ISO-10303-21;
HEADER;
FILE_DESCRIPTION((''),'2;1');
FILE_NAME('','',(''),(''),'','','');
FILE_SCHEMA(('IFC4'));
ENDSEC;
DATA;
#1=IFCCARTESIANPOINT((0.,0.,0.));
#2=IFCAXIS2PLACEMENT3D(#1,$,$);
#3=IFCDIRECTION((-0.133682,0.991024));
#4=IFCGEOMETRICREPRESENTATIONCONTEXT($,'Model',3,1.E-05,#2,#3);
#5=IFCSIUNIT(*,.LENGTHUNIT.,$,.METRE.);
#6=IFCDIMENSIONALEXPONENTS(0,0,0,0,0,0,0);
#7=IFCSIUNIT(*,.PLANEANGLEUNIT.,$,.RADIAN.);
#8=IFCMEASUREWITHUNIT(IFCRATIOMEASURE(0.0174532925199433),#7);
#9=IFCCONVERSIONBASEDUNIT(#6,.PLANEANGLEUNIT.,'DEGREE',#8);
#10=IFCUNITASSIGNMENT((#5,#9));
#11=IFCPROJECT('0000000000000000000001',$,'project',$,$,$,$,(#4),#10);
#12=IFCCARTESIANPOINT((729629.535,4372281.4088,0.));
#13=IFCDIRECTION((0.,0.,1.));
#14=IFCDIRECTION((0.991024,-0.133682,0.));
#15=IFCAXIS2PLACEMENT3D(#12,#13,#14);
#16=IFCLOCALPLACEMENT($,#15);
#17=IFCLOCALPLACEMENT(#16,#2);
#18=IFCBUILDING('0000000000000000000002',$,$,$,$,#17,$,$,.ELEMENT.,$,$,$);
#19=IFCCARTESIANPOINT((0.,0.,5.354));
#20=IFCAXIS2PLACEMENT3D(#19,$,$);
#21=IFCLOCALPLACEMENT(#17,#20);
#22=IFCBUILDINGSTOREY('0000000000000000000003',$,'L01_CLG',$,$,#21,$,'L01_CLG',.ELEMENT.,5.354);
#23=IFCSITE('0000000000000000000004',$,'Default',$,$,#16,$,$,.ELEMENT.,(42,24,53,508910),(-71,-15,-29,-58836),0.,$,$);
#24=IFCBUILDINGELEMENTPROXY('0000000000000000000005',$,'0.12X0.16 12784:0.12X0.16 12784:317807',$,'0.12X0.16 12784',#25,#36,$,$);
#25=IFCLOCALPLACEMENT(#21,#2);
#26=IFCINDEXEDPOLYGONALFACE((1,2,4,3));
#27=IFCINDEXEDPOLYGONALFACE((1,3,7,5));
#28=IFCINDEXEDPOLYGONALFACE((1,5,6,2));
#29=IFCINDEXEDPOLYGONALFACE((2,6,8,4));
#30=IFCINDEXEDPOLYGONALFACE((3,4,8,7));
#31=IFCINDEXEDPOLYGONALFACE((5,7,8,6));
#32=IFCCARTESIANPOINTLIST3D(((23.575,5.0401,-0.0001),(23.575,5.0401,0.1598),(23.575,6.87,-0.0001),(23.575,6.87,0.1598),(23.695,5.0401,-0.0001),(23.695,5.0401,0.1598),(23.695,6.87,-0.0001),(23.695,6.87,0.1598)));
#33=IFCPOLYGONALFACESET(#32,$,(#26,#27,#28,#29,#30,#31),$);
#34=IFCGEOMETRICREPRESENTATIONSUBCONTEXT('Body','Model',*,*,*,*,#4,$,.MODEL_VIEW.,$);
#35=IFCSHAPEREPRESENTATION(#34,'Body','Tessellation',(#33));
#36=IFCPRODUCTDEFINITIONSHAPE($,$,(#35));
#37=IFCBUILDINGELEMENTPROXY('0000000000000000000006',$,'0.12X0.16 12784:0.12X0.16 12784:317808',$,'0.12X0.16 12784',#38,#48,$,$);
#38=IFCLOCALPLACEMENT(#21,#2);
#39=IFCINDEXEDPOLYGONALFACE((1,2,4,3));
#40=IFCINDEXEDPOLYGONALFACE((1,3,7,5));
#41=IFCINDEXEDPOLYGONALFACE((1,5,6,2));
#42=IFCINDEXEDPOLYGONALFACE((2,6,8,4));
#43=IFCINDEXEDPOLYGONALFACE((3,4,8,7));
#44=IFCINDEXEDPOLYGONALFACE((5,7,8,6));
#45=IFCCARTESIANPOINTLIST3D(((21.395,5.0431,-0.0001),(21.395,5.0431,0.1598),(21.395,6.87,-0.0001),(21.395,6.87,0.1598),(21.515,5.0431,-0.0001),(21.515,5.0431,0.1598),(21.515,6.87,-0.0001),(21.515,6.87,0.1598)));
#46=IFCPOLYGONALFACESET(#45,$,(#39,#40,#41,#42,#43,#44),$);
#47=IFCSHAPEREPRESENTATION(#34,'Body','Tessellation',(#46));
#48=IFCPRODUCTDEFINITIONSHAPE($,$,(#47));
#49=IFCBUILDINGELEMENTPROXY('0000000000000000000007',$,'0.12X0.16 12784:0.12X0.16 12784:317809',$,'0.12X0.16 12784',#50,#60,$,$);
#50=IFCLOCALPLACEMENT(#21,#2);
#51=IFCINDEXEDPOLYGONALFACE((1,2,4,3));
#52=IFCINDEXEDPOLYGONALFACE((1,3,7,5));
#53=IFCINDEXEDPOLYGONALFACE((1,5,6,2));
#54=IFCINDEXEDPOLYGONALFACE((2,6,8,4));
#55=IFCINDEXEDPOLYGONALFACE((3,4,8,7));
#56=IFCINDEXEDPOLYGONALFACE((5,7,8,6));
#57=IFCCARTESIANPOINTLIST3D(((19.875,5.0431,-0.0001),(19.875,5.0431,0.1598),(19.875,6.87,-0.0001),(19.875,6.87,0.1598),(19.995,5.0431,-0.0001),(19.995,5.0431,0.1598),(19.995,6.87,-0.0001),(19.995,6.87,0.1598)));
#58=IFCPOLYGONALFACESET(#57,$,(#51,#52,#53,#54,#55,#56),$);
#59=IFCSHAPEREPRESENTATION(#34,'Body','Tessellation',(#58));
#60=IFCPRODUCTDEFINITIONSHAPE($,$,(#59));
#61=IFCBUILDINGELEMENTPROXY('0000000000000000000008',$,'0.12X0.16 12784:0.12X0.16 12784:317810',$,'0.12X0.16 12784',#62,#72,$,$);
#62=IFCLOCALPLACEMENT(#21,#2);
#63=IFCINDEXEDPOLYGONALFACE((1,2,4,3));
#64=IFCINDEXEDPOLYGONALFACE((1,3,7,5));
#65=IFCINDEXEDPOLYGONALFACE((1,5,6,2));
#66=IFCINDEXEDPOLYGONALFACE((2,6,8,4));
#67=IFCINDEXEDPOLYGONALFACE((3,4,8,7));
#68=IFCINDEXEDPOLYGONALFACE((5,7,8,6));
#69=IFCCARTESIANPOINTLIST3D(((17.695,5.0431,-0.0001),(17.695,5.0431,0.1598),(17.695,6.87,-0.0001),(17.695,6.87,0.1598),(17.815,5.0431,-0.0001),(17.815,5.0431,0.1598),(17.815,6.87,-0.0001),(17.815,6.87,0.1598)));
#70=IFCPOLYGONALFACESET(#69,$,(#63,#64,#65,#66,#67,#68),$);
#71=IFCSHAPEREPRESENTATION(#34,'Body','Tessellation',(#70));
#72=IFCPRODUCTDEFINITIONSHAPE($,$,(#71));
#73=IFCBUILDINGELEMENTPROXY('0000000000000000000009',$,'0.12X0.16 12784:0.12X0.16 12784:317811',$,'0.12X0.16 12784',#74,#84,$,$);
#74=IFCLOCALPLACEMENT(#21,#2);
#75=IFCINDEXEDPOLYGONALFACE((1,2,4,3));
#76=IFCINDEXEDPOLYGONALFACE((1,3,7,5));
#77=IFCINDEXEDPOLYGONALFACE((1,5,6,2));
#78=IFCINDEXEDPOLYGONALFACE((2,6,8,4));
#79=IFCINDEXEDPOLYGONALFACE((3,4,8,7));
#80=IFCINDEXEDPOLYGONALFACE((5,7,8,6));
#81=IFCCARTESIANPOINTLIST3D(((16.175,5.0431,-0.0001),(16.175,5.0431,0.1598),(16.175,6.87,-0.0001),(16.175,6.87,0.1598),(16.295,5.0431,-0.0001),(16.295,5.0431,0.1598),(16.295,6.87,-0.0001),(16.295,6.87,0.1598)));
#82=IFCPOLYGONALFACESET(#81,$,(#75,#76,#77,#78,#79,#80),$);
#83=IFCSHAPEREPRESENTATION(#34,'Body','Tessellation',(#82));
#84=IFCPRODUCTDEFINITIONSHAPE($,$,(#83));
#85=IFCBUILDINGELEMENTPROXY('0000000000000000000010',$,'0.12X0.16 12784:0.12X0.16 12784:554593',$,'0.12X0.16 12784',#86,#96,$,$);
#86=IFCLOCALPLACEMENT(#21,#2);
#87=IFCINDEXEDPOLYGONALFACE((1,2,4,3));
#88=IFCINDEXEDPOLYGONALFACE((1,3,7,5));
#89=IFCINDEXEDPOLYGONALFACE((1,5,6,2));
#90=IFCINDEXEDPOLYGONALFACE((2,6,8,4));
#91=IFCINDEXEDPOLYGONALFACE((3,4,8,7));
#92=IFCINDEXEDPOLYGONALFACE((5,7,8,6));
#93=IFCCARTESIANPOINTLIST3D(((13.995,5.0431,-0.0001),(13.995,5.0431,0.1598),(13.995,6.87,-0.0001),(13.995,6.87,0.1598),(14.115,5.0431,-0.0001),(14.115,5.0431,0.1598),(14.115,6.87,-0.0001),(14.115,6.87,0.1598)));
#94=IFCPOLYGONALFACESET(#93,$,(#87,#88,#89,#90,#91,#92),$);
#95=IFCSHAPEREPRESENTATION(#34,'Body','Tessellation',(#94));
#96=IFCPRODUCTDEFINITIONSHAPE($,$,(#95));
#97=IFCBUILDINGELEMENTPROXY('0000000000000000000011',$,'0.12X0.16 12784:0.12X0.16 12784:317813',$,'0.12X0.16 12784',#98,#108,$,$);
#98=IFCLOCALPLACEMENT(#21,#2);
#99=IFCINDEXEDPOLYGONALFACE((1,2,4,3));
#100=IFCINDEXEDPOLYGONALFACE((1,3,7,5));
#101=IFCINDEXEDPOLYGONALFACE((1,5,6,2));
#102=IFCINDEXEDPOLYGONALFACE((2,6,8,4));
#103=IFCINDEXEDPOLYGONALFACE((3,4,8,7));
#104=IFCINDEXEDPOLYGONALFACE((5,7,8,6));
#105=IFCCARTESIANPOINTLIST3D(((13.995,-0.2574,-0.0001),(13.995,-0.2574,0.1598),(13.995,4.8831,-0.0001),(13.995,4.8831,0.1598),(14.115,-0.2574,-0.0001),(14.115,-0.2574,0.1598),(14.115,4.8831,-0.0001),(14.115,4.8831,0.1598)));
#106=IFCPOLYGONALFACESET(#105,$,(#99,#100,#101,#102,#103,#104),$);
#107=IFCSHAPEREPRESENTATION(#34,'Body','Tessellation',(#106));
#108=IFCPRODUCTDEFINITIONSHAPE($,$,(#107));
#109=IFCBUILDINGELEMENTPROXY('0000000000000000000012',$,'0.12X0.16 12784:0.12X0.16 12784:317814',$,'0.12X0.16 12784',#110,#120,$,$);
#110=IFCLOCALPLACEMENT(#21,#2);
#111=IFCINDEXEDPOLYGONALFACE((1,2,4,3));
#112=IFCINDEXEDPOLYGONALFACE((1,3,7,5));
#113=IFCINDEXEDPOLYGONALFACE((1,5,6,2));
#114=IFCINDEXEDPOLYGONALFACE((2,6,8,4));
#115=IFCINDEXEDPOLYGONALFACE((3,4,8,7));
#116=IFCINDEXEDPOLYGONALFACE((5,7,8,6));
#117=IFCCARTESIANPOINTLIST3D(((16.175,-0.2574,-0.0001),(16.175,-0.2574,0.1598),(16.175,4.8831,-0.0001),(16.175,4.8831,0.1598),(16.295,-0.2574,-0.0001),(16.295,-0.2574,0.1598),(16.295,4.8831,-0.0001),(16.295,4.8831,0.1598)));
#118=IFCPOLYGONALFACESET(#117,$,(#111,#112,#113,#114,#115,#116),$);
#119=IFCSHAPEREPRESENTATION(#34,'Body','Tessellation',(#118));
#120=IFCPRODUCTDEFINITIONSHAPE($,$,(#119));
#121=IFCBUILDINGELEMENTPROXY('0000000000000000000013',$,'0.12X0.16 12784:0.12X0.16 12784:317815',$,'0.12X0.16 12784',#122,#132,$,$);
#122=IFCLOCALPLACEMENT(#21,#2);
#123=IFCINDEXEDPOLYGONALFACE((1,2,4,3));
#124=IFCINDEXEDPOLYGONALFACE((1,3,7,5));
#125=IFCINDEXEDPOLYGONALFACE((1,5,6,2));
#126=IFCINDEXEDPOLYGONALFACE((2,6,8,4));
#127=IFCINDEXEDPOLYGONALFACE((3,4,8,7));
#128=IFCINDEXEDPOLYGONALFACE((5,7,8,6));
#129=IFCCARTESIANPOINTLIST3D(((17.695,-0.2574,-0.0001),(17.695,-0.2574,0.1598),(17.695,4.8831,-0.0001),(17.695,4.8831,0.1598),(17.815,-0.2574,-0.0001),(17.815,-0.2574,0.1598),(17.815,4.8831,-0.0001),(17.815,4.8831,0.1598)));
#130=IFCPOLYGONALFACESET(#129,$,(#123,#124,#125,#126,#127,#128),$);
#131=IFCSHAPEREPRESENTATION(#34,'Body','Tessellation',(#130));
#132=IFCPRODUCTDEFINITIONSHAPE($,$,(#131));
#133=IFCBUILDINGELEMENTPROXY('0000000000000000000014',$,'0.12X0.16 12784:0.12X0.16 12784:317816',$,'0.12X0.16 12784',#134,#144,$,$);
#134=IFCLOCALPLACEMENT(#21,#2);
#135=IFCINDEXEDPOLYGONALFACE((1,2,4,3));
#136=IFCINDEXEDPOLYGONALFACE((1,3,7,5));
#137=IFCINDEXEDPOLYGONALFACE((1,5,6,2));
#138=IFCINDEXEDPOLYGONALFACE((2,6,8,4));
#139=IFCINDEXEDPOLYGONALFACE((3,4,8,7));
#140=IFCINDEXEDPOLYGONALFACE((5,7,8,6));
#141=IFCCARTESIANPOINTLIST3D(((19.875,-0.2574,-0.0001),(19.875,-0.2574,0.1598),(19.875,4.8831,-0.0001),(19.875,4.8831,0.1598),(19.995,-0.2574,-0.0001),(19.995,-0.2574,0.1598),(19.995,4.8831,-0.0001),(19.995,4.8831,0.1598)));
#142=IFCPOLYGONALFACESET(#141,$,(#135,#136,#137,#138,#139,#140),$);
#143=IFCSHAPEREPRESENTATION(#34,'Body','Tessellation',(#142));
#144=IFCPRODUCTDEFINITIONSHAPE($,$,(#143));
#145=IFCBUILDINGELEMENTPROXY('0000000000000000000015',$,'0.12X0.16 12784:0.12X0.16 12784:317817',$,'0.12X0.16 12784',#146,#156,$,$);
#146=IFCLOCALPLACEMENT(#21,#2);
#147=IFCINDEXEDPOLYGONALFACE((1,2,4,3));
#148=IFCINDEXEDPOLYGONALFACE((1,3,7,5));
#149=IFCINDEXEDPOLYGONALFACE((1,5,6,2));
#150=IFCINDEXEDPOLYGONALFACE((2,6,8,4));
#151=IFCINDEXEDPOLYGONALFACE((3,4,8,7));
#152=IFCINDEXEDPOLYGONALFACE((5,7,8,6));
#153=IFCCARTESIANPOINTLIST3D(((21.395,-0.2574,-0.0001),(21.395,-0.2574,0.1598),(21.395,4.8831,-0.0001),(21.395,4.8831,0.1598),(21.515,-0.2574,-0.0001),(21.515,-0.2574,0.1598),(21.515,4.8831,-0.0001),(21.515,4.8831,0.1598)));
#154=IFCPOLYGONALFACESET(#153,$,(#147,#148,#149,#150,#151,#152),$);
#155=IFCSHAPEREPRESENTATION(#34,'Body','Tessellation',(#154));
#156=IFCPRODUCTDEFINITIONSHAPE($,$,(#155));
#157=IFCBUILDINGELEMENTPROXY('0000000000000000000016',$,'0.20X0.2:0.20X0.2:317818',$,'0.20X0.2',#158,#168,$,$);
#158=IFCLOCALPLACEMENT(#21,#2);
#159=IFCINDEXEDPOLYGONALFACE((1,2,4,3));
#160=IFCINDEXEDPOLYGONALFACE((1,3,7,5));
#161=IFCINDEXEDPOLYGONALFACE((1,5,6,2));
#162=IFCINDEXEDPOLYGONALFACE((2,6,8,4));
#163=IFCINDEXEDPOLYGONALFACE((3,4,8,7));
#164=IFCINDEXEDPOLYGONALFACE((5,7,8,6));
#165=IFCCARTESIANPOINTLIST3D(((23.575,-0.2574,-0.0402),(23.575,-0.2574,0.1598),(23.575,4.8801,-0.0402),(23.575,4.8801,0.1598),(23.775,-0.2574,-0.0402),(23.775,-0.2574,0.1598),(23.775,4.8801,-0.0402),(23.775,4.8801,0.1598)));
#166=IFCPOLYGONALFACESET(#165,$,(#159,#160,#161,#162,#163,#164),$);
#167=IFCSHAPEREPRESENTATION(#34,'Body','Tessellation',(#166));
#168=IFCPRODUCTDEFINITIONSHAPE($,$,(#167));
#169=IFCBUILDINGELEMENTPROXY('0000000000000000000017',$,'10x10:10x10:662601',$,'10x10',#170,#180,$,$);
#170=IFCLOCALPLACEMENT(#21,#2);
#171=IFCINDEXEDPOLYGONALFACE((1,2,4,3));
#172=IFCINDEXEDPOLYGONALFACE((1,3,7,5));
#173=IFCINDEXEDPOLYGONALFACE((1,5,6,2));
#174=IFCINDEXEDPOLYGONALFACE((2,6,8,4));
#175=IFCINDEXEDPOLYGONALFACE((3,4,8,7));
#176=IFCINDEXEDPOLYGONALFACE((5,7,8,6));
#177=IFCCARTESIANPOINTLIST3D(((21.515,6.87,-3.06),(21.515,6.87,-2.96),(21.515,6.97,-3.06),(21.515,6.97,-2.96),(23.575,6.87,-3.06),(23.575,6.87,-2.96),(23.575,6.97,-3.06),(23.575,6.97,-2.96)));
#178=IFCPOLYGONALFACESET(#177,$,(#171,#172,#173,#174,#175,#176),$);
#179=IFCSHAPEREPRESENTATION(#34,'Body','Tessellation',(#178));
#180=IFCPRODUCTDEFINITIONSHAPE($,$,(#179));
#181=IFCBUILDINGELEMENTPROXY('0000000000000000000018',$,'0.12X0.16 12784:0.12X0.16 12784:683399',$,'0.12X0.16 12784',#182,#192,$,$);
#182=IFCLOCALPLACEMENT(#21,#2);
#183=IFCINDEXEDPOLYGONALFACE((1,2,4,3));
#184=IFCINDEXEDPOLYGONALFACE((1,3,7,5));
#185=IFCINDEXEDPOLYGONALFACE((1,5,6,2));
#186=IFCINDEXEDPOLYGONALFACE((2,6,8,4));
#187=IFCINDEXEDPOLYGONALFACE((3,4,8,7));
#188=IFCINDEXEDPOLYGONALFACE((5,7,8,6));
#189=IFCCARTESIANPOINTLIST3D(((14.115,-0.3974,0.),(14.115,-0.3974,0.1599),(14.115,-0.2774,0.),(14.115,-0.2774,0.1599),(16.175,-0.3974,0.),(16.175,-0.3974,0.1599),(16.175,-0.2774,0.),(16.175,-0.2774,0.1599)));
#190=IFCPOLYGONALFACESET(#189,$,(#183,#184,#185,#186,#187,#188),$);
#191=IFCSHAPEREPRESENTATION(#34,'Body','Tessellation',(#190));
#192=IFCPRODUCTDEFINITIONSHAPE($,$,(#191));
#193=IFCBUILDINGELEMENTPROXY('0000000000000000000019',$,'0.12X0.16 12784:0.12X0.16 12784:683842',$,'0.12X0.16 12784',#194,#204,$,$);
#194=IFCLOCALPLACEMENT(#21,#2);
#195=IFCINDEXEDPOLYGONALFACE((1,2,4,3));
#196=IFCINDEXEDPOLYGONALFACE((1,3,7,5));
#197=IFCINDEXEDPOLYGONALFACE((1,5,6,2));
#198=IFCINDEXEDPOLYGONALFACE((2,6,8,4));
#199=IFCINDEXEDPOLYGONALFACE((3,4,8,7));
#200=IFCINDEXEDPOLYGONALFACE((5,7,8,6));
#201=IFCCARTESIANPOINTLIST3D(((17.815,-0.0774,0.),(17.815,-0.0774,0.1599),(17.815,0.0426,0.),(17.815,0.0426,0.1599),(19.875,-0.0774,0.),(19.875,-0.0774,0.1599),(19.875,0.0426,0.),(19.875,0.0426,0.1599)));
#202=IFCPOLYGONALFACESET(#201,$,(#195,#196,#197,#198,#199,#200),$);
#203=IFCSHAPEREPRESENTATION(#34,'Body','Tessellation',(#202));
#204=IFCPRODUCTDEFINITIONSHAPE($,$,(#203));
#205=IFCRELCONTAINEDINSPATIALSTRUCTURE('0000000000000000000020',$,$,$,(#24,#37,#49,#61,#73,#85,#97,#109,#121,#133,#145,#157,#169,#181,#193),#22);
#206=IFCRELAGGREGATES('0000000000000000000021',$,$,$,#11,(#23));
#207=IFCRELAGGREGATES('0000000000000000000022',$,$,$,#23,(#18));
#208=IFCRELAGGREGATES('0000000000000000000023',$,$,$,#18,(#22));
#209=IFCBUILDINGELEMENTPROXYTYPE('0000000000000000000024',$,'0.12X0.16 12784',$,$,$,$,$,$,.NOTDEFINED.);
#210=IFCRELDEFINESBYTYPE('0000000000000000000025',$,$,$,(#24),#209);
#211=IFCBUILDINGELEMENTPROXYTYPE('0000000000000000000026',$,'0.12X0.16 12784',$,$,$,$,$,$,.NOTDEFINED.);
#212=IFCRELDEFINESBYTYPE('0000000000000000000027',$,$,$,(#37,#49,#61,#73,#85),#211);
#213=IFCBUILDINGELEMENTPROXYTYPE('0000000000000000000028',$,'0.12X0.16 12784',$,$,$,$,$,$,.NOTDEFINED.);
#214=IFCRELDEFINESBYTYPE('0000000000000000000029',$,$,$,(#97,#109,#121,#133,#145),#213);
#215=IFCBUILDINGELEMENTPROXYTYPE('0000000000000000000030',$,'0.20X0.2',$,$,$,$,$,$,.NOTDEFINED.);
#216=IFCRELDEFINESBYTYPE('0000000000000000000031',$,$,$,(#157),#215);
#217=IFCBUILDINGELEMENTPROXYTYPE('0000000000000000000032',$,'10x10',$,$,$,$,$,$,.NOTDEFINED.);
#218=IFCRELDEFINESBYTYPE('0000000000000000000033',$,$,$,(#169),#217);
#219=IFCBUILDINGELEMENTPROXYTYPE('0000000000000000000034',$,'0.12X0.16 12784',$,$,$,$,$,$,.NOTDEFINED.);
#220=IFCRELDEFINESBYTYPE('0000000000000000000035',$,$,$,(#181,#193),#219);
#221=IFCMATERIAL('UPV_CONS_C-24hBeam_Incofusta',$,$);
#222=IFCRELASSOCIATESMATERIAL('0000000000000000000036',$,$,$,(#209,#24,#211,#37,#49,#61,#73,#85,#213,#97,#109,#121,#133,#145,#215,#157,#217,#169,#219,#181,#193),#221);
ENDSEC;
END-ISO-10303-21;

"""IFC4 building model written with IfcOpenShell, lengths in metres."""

from ifc_helpers import new_model, entity, si_unit, converted_unit, direction, frame, frame_2d, origin, origin_2d_with_axis, place, context, subcontext, project, spatial, rectangle, extrude, source, transform, mapped, material, type_object, type_shapes, element, save


model = new_model("IFC4")

# Units and contexts
model_context = context("Model", 3, precision=1e-05, world=origin(), true_north=direction((-0.133682, 0.991024)))
body_context = subcontext(model_context, "Body", "Model", "MODEL_VIEW")
ifc_project = project(units=[si_unit("LENGTHUNIT", "METRE"), converted_unit("PLANEANGLEUNIT", "DEGREE", entity("IfcRatioMeasure", 0.0174532925199433), si_unit("PLANEANGLEUNIT", "RADIAN"), dimensions=[0, 0, 0, 0, 0, 0, 0])], contexts=[model_context])

# Site, building, storey
site_placement = place(None, frame((729629.535, 4372281.4088, 0.0), z_axis=(0.0, 0.0, 1.0), x_axis=(0.991024, -0.133682, 0.0)))
site = spatial("IfcSite", under=ifc_project, at=site_placement, Name="Default", CompositionType="ELEMENT", RefLatitude=(42, 24, 53, 508910), RefLongitude=(-71, -15, -29, -58836), RefElevation=0.0)
building_placement = place(site_placement, origin())
building = spatial("IfcBuilding", under=site, at=building_placement, CompositionType="ELEMENT")
storey_placement = place(building_placement, frame((0.0, 0.0, 5.354)))
storey = spatial("IfcBuildingStorey", under=building, at=storey_placement, Name="L01_CLG", LongName="L01_CLG", CompositionType="ELEMENT", Elevation=5.354)

# Building element proxies
ifc_material_1 = material(Name="UPV_CONS_C-24hBeam_Incofusta")
building_element_proxy_type_1 = type_object("IfcBuildingElementProxyType", Name="0.12X0.16 12784", material=ifc_material_1)
shared_shape_1 = source(origin(), body_context, "Body", "SweptSolid", [
    extrude(rectangle(XDim=0.12, YDim=1.8299, at=frame_2d((0.0, 0.0), x_axis=(1.0, 0.0))), frame((0.9149, 0.06, 0.0), z_axis=(0.0, 0.0, 1.0), x_axis=(0.0, -1.0, 0.0)), (0.0, 0.0, 1.0), 0.1599),
])
type_shapes(building_element_proxy_type_1, [shared_shape_1])
proxy_1_placement = place(storey_placement, frame((23.575, 6.87, -0.0001), z_axis=(0.0, 0.0, 1.0), x_axis=(0.0, -1.0, 0.0)))
element("IfcBuildingElementProxy", 1, at=proxy_1_placement, inside=storey, type_object=building_element_proxy_type_1, material=ifc_material_1, Name="0.12X0.16 12784:0.12X0.16 12784:317807", ObjectType="0.12X0.16 12784", context=body_context, shape_type="MappedRepresentation", body=[
    mapped(shared_shape_1, transform((0.0, 0.0, 0.0), scale=1.0)),
])
building_element_proxy_type_2 = type_object("IfcBuildingElementProxyType", Name="0.12X0.16 12784", material=ifc_material_1)
shared_shape_2 = source(origin(), body_context, "Body", "SweptSolid", [
    extrude(rectangle(XDim=0.12, YDim=1.8269, at=frame_2d((0.0, 0.0), x_axis=(1.0, 0.0))), frame((0.9135, 0.06, 0.0), z_axis=(0.0, 0.0, 1.0), x_axis=(0.0, -1.0, 0.0)), (0.0, 0.0, 1.0), 0.1599),
])
type_shapes(building_element_proxy_type_2, [shared_shape_2])
for number, where, z_axis, x_axis, name in (
    (2, (21.395, 6.87, -0.0001), (0.0, 0.0, 1.0), (0.0, -1.0, 0.0), "0.12X0.16 12784:0.12X0.16 12784:317808"),
    (3, (19.875, 6.87, -0.0001), (0.0, 0.0, 1.0), (0.0, -1.0, 0.0), "0.12X0.16 12784:0.12X0.16 12784:317809"),
    (4, (17.695, 6.87, -0.0001), (0.0, 0.0, 1.0), (0.0, -1.0, 0.0), "0.12X0.16 12784:0.12X0.16 12784:317810"),
    (5, (16.175, 6.87, -0.0001), (0.0, 0.0, 1.0), (0.0, -1.0, 0.0), "0.12X0.16 12784:0.12X0.16 12784:317811"),
    (6, (13.995, 6.87, -0.0001), (0.0, 0.0, 1.0), (0.0, -1.0, 0.0), "0.12X0.16 12784:0.12X0.16 12784:554593"),
):
    element("IfcBuildingElementProxy", number, at=place(storey_placement, frame(where, z_axis=z_axis, x_axis=x_axis)), inside=storey, type_object=building_element_proxy_type_2, material=ifc_material_1, Name=name, ObjectType="0.12X0.16 12784", context=body_context, shape_type="MappedRepresentation", body=[
        mapped(shared_shape_2, transform((0.0, 0.0, 0.0), scale=1.0)),
    ])
building_element_proxy_type_3 = type_object("IfcBuildingElementProxyType", Name="0.12X0.16 12784", material=ifc_material_1)
shared_shape_3 = source(origin(), body_context, "Body", "SweptSolid", [
    extrude(rectangle(XDim=0.12, YDim=5.1404, at=origin_2d_with_axis()), frame((-0.0488, 0.0, -0.0799), z_axis=(0.0, 0.0, 1.0), x_axis=(0.0, -1.0, 0.0)), (0.0, 0.0, 1.0), 0.1599),
])
type_shapes(building_element_proxy_type_3, [shared_shape_3])
for number, where, z_axis, x_axis, name in (
    (7, (14.055, 2.3616, 0.0798), (0.0, 0.0, 1.0), (0.0, 1.0, 0.0), "0.12X0.16 12784:0.12X0.16 12784:317813"),
    (8, (16.235, 2.3616, 0.0798), (0.0, 0.0, 1.0), (0.0, 1.0, 0.0), "0.12X0.16 12784:0.12X0.16 12784:317814"),
    (9, (17.755, 2.3616, 0.0798), (0.0, 0.0, 1.0), (0.0, 1.0, 0.0), "0.12X0.16 12784:0.12X0.16 12784:317815"),
    (10, (19.935, 2.3616, 0.0798), (0.0, 0.0, 1.0), (0.0, 1.0, 0.0), "0.12X0.16 12784:0.12X0.16 12784:317816"),
    (11, (21.455, 2.3616, 0.0798), (0.0, 0.0, 1.0), (0.0, 1.0, 0.0), "0.12X0.16 12784:0.12X0.16 12784:317817"),
):
    element("IfcBuildingElementProxy", number, at=place(storey_placement, frame(where, z_axis=z_axis, x_axis=x_axis)), inside=storey, type_object=building_element_proxy_type_3, material=ifc_material_1, Name=name, ObjectType="0.12X0.16 12784", context=body_context, shape_type="MappedRepresentation", body=[
        mapped(shared_shape_3, transform((0.0, 0.0, 0.0), scale=1.0)),
    ])
building_element_proxy_type_4 = type_object("IfcBuildingElementProxyType", Name="0.20X0.2", material=ifc_material_1)
shared_shape_4 = source(origin(), body_context, "Body", "SweptSolid", [
    extrude(rectangle(XDim=0.2, YDim=5.1375, at=origin_2d_with_axis()), frame((-0.0502, 0.0, -0.0999), z_axis=(0.0, 0.0, 1.0), x_axis=(0.0, -1.0, 0.0)), (0.0, 0.0, 1.0), 0.2),
])
type_shapes(building_element_proxy_type_4, [shared_shape_4])
proxy_2_placement = place(storey_placement, frame((23.675, 2.3616, 0.0597), z_axis=(0.0, 0.0, 1.0), x_axis=(0.0, 1.0, 0.0)))
element("IfcBuildingElementProxy", 12, at=proxy_2_placement, inside=storey, type_object=building_element_proxy_type_4, material=ifc_material_1, Name="0.20X0.2:0.20X0.2:317818", ObjectType="0.20X0.2", context=body_context, shape_type="MappedRepresentation", body=[
    mapped(shared_shape_4, transform((0.0, 0.0, 0.0), scale=1.0)),
])
building_element_proxy_type_5 = type_object("IfcBuildingElementProxyType", Name="10x10", material=ifc_material_1)
shared_shape_5 = source(origin(), body_context, "Body", "SweptSolid", [
    extrude(rectangle(XDim=0.1, YDim=2.06, at=frame_2d((0.0, 0.0), x_axis=(1.0, 0.0))), frame((1.03, 0.05, 0.0), z_axis=(0.0, 0.0, 1.0), x_axis=(0.0, -1.0, 0.0)), (0.0, 0.0, 1.0), 0.1),
])
type_shapes(building_element_proxy_type_5, [shared_shape_5])
proxy_3_placement = place(storey_placement, frame((21.515, 6.87, -3.06)))
element("IfcBuildingElementProxy", 13, at=proxy_3_placement, inside=storey, type_object=building_element_proxy_type_5, material=ifc_material_1, Name="10x10:10x10:662601", ObjectType="10x10", context=body_context, shape_type="MappedRepresentation", body=[
    mapped(shared_shape_5, transform((0.0, 0.0, 0.0), scale=1.0)),
])
building_element_proxy_type_6 = type_object("IfcBuildingElementProxyType", Name="0.12X0.16 12784", material=ifc_material_1)
shared_shape_6 = source(origin(), body_context, "Body", "SweptSolid", [
    extrude(rectangle(XDim=0.12, YDim=2.06, at=frame_2d((0.0, 0.0), x_axis=(1.0, 0.0))), frame((1.03, 0.06, 0.0), z_axis=(0.0, 0.0, 1.0), x_axis=(0.0, -1.0, 0.0)), (0.0, 0.0, 1.0), 0.1599),
])
type_shapes(building_element_proxy_type_6, [shared_shape_6])
for number, where, name in (
    (14, (14.115, -0.3974, 0.0), "0.12X0.16 12784:0.12X0.16 12784:683399"),
    (15, (17.815, -0.0774, 0.0), "0.12X0.16 12784:0.12X0.16 12784:683842"),
):
    element("IfcBuildingElementProxy", number, at=place(storey_placement, frame(where)), inside=storey, type_object=building_element_proxy_type_6, material=ifc_material_1, Name=name, ObjectType="0.12X0.16 12784", context=body_context, shape_type="MappedRepresentation", body=[
        mapped(shared_shape_6, transform((0.0, 0.0, 0.0), scale=1.0)),
    ])

save(model, "model.ifc")
